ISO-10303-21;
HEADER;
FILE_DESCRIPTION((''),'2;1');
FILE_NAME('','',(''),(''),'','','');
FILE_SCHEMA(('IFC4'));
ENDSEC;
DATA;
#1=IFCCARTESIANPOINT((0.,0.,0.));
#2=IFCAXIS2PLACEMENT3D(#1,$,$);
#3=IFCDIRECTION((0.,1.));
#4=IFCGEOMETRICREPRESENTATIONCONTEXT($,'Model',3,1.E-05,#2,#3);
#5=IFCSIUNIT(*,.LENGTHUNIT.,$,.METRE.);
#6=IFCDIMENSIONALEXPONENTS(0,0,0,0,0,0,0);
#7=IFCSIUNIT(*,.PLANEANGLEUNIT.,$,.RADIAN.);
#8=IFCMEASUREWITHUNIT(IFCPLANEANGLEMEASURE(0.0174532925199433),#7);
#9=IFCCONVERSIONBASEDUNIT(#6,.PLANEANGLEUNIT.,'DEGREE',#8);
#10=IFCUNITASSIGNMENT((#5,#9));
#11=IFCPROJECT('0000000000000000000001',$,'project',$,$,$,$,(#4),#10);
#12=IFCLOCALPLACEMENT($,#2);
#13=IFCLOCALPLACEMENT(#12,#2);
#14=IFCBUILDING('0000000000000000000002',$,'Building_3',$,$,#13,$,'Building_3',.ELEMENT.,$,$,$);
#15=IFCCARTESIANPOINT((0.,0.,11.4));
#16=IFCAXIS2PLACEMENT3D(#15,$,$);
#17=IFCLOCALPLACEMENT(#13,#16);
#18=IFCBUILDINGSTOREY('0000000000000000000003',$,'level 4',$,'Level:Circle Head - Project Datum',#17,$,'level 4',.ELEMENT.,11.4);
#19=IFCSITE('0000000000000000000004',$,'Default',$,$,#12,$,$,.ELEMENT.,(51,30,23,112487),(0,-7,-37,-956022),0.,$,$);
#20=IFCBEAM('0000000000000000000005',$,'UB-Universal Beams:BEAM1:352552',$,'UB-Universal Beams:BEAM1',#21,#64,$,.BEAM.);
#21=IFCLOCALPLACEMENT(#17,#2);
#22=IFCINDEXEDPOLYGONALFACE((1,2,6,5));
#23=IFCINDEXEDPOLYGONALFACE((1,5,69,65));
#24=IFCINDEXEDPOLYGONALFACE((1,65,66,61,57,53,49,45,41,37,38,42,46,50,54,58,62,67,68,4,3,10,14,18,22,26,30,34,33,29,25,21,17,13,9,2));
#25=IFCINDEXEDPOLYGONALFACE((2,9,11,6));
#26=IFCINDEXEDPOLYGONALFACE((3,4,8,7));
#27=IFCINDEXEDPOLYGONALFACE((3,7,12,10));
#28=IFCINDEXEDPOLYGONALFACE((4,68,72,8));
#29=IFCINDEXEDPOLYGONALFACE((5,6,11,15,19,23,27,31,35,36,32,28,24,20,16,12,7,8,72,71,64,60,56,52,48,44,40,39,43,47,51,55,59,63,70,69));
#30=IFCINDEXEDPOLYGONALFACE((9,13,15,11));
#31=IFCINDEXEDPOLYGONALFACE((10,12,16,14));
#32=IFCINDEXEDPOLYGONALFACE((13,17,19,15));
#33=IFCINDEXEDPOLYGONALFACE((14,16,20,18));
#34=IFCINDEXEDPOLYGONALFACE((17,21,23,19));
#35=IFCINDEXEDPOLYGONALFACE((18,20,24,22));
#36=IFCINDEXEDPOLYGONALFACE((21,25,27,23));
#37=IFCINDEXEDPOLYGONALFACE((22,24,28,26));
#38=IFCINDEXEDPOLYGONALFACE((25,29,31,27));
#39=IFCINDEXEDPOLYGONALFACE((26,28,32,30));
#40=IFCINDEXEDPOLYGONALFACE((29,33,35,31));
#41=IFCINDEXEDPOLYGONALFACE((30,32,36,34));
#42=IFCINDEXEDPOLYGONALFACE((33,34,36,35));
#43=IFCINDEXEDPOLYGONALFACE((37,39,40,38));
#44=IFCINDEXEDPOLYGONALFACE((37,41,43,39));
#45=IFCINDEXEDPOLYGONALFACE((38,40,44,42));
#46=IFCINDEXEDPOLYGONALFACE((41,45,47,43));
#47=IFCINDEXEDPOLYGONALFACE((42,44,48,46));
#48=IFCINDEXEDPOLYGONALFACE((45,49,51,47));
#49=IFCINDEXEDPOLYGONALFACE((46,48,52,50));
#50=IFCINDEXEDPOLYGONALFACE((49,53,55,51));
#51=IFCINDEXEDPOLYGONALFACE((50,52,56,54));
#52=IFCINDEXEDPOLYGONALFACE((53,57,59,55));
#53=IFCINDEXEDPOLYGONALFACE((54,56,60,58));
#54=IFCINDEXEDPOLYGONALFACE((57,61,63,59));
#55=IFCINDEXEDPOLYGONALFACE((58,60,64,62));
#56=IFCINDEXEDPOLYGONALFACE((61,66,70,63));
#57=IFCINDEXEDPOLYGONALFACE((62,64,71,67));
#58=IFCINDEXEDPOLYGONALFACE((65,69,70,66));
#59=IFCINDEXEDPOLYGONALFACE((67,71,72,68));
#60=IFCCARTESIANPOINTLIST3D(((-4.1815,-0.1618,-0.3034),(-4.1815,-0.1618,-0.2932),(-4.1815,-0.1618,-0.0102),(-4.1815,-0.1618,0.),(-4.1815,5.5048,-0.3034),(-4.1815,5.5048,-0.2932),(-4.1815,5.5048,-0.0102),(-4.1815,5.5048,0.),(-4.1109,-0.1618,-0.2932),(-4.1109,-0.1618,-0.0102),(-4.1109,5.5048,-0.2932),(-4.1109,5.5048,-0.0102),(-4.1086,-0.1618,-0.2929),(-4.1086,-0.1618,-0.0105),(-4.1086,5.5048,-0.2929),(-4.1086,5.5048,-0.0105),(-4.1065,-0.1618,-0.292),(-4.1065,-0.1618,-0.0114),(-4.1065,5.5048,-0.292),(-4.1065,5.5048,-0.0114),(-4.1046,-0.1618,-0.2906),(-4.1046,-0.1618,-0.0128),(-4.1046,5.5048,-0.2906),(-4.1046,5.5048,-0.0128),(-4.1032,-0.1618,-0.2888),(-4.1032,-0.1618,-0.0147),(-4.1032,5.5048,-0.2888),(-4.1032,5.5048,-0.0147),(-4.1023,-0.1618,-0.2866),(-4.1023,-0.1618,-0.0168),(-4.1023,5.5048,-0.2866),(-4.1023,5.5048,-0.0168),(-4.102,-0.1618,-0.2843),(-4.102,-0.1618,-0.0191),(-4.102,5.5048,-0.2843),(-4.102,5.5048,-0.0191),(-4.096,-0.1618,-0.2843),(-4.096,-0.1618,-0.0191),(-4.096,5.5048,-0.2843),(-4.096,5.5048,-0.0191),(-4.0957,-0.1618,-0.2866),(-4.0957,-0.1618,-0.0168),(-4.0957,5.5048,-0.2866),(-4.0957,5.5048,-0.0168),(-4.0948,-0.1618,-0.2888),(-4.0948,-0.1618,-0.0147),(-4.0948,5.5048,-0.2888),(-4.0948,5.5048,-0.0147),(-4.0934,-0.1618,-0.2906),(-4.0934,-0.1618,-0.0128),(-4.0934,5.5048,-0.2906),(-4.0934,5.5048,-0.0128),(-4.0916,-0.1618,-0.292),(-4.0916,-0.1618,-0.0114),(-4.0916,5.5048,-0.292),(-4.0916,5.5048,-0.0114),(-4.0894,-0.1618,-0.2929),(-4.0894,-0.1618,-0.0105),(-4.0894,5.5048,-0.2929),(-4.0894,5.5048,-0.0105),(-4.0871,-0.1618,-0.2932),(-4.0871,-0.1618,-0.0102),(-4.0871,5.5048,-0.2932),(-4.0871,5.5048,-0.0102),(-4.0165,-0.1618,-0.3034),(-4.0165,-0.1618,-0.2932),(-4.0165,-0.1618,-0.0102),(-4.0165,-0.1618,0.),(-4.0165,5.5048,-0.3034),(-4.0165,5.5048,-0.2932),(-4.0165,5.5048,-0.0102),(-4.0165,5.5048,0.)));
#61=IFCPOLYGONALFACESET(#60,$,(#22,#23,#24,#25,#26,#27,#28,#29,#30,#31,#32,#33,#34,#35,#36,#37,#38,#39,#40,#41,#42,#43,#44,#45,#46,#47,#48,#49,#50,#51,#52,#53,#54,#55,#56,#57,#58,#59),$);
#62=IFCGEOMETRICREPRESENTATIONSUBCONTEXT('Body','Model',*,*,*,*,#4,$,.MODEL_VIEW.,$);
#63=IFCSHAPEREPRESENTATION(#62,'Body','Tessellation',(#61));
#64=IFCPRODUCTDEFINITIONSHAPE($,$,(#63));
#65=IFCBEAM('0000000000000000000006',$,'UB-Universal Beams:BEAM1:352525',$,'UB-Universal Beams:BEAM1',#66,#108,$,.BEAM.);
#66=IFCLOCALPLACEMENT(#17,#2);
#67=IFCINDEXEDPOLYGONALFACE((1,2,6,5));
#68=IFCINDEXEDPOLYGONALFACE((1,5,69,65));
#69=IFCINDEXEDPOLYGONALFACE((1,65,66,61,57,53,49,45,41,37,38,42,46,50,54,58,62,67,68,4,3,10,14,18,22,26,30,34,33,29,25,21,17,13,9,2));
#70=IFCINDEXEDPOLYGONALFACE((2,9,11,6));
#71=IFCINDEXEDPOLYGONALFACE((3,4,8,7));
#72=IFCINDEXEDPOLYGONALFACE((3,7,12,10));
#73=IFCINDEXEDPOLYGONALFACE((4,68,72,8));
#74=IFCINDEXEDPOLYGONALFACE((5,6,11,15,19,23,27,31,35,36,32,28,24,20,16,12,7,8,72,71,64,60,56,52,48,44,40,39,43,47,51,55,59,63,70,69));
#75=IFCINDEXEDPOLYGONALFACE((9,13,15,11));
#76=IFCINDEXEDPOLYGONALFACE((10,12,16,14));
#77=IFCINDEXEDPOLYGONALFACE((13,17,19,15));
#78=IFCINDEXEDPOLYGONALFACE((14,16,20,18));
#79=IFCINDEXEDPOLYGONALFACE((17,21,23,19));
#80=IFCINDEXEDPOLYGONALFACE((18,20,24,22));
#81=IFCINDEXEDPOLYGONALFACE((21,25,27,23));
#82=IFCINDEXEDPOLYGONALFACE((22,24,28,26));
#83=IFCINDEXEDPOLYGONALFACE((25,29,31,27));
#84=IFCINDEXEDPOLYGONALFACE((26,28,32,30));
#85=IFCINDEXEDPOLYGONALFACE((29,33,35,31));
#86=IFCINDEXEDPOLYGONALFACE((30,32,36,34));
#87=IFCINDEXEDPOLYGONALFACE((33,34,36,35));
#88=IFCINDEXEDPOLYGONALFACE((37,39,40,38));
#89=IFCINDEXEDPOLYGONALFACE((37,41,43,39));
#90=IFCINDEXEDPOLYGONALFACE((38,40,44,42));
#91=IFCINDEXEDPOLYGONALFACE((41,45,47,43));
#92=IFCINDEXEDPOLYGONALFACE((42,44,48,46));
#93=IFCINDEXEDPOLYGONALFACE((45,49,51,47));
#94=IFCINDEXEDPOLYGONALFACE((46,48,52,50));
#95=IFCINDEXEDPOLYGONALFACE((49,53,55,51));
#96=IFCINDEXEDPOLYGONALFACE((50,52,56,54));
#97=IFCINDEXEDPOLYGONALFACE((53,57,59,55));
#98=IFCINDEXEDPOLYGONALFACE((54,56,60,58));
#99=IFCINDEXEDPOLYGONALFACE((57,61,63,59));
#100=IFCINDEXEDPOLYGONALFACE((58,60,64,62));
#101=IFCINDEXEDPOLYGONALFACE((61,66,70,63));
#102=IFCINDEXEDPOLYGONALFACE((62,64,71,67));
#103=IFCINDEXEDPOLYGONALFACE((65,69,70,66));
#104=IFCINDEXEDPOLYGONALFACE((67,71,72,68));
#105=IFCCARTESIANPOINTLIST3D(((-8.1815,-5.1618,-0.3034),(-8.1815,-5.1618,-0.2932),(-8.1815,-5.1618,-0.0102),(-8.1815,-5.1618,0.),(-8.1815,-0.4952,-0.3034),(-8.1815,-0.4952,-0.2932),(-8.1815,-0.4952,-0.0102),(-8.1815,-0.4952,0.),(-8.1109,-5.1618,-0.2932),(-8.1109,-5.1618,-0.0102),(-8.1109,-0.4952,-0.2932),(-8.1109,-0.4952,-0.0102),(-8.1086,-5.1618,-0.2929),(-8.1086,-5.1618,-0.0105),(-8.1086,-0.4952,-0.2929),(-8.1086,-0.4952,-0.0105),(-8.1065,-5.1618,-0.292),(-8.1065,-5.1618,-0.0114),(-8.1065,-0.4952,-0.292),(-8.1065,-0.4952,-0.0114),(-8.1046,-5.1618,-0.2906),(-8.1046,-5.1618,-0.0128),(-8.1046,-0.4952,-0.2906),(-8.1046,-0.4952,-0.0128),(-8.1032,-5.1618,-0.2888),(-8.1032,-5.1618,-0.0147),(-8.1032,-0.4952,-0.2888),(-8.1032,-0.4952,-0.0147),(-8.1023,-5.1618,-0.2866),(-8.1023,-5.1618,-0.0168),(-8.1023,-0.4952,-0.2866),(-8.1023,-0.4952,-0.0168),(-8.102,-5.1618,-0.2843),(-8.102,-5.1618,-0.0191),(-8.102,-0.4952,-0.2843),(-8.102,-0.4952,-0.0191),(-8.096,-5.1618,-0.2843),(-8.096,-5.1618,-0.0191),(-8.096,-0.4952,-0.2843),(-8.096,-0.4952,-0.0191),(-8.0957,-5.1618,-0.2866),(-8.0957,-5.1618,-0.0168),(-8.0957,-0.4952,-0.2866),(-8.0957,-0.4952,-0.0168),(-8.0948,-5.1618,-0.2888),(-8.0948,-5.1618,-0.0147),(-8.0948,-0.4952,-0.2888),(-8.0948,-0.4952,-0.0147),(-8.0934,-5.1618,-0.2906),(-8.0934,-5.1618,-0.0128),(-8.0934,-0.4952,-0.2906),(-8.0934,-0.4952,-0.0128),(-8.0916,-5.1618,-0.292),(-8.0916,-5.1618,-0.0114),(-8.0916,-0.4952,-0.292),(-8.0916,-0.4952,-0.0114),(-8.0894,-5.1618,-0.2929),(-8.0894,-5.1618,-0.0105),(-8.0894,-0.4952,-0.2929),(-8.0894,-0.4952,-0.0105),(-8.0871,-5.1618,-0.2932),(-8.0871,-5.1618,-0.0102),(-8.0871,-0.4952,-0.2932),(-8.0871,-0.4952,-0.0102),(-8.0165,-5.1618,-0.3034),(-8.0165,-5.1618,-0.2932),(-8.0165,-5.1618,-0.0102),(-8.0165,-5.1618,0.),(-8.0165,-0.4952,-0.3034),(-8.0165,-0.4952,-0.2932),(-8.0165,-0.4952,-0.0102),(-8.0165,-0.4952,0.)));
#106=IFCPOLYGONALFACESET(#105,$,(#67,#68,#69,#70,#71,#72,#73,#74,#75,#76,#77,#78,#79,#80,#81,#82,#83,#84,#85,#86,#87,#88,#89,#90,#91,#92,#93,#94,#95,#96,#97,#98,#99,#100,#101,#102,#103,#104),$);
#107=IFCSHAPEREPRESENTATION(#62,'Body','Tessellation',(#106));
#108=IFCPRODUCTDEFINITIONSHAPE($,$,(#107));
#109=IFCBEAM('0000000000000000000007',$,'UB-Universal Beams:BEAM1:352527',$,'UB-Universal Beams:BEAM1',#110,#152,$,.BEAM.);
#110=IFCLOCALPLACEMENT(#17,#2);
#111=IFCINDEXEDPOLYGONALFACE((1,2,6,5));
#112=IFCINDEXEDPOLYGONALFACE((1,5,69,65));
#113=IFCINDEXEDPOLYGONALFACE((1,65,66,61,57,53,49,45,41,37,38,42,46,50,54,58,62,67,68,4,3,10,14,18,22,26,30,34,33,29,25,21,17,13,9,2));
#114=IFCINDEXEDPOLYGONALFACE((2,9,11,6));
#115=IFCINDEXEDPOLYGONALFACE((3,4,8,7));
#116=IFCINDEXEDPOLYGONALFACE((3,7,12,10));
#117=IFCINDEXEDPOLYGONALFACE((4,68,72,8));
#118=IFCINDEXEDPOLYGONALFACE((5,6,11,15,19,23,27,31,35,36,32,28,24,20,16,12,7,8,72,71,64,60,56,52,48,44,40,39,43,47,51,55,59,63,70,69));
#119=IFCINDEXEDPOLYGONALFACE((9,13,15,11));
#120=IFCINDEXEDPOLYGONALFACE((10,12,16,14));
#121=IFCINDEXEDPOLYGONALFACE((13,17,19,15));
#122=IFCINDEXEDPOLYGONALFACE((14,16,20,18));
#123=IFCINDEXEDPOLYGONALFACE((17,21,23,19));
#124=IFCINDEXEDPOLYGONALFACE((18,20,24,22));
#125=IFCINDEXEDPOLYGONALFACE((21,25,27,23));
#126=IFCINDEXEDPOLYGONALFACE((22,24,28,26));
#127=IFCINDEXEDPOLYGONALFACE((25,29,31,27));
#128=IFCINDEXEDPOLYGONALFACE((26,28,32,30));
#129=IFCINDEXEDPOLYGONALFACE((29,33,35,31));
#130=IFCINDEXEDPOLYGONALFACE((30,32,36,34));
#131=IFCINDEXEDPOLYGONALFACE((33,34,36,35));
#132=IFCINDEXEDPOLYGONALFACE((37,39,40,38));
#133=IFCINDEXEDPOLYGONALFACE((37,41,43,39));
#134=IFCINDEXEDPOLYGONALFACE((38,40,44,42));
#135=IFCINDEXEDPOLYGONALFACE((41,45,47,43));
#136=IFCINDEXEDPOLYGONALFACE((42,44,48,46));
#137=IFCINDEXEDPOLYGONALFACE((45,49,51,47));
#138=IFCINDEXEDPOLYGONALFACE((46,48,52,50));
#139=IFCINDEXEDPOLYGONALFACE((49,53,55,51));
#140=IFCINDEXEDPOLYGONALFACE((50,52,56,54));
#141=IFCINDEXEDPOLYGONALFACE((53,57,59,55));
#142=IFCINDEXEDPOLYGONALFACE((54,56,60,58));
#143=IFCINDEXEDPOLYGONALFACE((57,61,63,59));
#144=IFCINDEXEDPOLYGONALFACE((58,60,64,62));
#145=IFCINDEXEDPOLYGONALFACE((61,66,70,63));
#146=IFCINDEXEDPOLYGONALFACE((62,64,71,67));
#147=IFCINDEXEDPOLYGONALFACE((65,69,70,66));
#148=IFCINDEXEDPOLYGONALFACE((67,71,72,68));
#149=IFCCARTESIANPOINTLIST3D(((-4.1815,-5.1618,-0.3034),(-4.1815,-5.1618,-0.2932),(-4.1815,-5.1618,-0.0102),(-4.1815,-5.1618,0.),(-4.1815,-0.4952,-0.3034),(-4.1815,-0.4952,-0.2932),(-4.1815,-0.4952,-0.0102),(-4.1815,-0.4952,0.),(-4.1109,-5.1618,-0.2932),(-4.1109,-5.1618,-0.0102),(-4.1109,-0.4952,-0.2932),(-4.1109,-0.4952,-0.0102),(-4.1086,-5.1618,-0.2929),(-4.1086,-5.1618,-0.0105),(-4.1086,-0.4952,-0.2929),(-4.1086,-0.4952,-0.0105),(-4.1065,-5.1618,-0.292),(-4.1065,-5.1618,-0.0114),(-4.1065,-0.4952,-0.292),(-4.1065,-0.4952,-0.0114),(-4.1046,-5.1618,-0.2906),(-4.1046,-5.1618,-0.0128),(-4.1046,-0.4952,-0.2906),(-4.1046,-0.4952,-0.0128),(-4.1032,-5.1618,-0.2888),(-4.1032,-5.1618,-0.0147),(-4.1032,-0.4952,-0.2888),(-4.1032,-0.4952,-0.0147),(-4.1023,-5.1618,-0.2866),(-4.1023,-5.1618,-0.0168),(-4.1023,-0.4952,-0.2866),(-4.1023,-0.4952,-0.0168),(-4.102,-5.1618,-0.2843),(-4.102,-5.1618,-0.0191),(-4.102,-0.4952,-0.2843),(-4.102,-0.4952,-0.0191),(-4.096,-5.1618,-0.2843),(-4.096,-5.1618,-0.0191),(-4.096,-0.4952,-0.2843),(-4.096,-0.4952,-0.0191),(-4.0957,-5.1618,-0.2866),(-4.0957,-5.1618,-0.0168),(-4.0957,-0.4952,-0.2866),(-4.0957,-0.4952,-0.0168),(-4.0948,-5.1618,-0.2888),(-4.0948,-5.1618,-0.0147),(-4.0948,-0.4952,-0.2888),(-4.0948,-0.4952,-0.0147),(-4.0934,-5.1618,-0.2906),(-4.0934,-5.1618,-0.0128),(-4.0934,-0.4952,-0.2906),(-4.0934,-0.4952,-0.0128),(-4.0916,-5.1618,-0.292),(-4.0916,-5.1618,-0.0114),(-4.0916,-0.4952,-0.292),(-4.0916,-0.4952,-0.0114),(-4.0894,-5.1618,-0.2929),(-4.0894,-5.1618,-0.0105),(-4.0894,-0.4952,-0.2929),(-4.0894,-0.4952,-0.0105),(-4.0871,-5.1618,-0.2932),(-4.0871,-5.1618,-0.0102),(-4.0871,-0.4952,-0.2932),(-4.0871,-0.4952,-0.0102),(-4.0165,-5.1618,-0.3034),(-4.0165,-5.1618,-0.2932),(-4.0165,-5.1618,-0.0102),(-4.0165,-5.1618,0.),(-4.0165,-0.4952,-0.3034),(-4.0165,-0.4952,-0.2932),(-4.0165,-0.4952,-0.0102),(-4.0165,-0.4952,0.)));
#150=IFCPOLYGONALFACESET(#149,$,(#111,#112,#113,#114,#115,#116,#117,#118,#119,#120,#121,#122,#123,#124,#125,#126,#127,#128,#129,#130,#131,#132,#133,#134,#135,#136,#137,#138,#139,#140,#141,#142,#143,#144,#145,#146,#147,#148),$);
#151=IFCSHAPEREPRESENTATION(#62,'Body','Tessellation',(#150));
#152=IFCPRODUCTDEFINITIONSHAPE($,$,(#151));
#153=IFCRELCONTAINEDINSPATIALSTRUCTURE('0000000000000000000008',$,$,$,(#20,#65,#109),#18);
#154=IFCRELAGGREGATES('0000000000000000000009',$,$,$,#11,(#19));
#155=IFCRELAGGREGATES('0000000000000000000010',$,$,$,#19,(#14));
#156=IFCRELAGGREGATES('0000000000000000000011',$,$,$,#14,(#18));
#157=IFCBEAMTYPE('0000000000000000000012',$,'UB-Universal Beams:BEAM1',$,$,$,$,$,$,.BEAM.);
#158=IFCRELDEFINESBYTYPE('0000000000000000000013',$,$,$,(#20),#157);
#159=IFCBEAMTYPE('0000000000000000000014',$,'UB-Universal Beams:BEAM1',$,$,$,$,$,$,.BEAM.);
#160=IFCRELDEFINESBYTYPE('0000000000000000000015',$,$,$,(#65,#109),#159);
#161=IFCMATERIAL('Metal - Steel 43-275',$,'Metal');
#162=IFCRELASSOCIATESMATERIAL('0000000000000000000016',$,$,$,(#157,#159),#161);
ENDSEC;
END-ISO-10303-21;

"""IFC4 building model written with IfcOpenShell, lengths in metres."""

from ifc_helpers import new_model, entity, si_unit, converted_unit, direction, frame, frame_2d, origin, place, context, subcontext, project, spatial, polyline, circle_curve, parameter, trimmed, segment, composite_curve, outline, extrude, source, transform, mapped, material, material_profile, profile_set, type_object, type_shapes, element, save


model = new_model("IFC4")

# Units and contexts
model_context = context("Model", 3, precision=1e-05, world=origin(), true_north=direction((0.0, 1.0)))
body_context = subcontext(model_context, "Body", "Model", "MODEL_VIEW")
ifc_project = project(units=[si_unit("LENGTHUNIT", "METRE"), converted_unit("PLANEANGLEUNIT", "DEGREE", entity("IfcPlaneAngleMeasure", 0.0174532925199433), si_unit("PLANEANGLEUNIT", "RADIAN"), dimensions=[0, 0, 0, 0, 0, 0, 0])], contexts=[model_context])

# Site, building, storey
site_placement = place(None, origin())
site = spatial("IfcSite", under=ifc_project, at=site_placement, Name="Default", CompositionType="ELEMENT", RefLatitude=(51, 30, 23, 112487), RefLongitude=(0, -7, -37, -956022), RefElevation=0.0)
building_placement = place(site_placement, origin())
building = spatial("IfcBuilding", under=site, at=building_placement, Name="Building_3", LongName="Building_3", CompositionType="ELEMENT")
storey_placement = place(building_placement, frame((0.0, 0.0, 11.4)))
storey = spatial("IfcBuildingStorey", under=building, at=storey_placement, Name="level 4", ObjectType="Level:Circle Head - Project Datum", LongName="level 4", CompositionType="ELEMENT", Elevation=11.4)

# Shared definitions
ifc_material_1 = material(Name="Metal - Steel 43-275", Category="Metal")

# Beams
ifc_material_profile_1 = material_profile(ifc_material_1, outline(composite_curve([segment(polyline([(-0.0825, -0.1415), (-0.0825, -0.1517)]), True, "CONTINUOUS"), segment(polyline([(-0.0825, -0.1517), (0.0825, -0.1517)]), True, "CONTINUOUS"), segment(polyline([(0.0825, -0.1517), (0.0825, -0.1415)]), True, "CONTINUOUS"), segment(polyline([(0.0825, -0.1415), (0.0119, -0.1415)]), True, "CONTINUOUS"), segment(trimmed(circle_curve(frame_2d((0.0119, -0.1326), x_axis=(1.0, 0.0)), 0.0089), [parameter(180.0)], [parameter(270.0)], True, "PARAMETER"), False, "CONTINUOUS"), segment(polyline([(0.003, -0.1326), (0.003, 0.1326)]), True, "CONTINUOUS"), segment(trimmed(circle_curve(frame_2d((0.0119, 0.1326), x_axis=(1.0, 0.0)), 0.0089), [parameter(90.0)], [parameter(180.0)], True, "PARAMETER"), False, "CONTINUOUS"), segment(polyline([(0.0119, 0.1415), (0.0825, 0.1415)]), True, "CONTINUOUS"), segment(polyline([(0.0825, 0.1415), (0.0825, 0.1517)]), True, "CONTINUOUS"), segment(polyline([(0.0825, 0.1517), (-0.0825, 0.1517)]), True, "CONTINUOUS"), segment(polyline([(-0.0825, 0.1517), (-0.0825, 0.1415)]), True, "CONTINUOUS"), segment(polyline([(-0.0825, 0.1415), (-0.0119, 0.1415)]), True, "CONTINUOUS"), segment(trimmed(circle_curve(frame_2d((-0.0119, 0.1326), x_axis=(1.0, 0.0)), 0.0089), [parameter(360.0)], [parameter(90.0)], True, "PARAMETER"), False, "CONTINUOUS"), segment(polyline([(-0.003, 0.1326), (-0.003, -0.1326)]), True, "CONTINUOUS"), segment(trimmed(circle_curve(frame_2d((-0.0119, -0.1326), x_axis=(1.0, 0.0)), 0.0089), [parameter(270.0)], [parameter(360.0)], True, "PARAMETER"), False, "CONTINUOUS"), segment(polyline([(-0.0119, -0.1415), (-0.0825, -0.1415)]), True, "CONTINUOUS")], self_intersect=False)), Name="BEAM1")
ifc_profile_set_1 = profile_set([ifc_material_profile_1], Name="BEAM1")
beam_type_1 = type_object("IfcBeamType", Name="UB-Universal Beams:BEAM1", PredefinedType="BEAM", material=ifc_profile_set_1)
shared_shape_1 = source(origin(), body_context, "Body", "SweptSolid", [
    extrude(outline(composite_curve([segment(polyline([(-0.0825, -0.1415), (-0.0825, -0.1517)]), True, "CONTINUOUS"), segment(polyline([(-0.0825, -0.1517), (0.0825, -0.1517)]), True, "CONTINUOUS"), segment(polyline([(0.0825, -0.1517), (0.0825, -0.1415)]), True, "CONTINUOUS"), segment(polyline([(0.0825, -0.1415), (0.0119, -0.1415)]), True, "CONTINUOUS"), segment(trimmed(circle_curve(frame_2d((0.0119, -0.1326), x_axis=(1.0, 0.0)), 0.0089), [parameter(180.0)], [parameter(270.0)], True, "PARAMETER"), False, "CONTINUOUS"), segment(polyline([(0.003, -0.1326), (0.003, 0.1326)]), True, "CONTINUOUS"), segment(trimmed(circle_curve(frame_2d((0.0119, 0.1326), x_axis=(1.0, 0.0)), 0.0089), [parameter(90.0)], [parameter(180.0)], True, "PARAMETER"), False, "CONTINUOUS"), segment(polyline([(0.0119, 0.1415), (0.0825, 0.1415)]), True, "CONTINUOUS"), segment(polyline([(0.0825, 0.1415), (0.0825, 0.1517)]), True, "CONTINUOUS"), segment(polyline([(0.0825, 0.1517), (-0.0825, 0.1517)]), True, "CONTINUOUS"), segment(polyline([(-0.0825, 0.1517), (-0.0825, 0.1415)]), True, "CONTINUOUS"), segment(polyline([(-0.0825, 0.1415), (-0.0119, 0.1415)]), True, "CONTINUOUS"), segment(trimmed(circle_curve(frame_2d((-0.0119, 0.1326), x_axis=(1.0, 0.0)), 0.0089), [parameter(360.0)], [parameter(90.0)], True, "PARAMETER"), False, "CONTINUOUS"), segment(polyline([(-0.003, 0.1326), (-0.003, -0.1326)]), True, "CONTINUOUS"), segment(trimmed(circle_curve(frame_2d((-0.0119, -0.1326), x_axis=(1.0, 0.0)), 0.0089), [parameter(270.0)], [parameter(360.0)], True, "PARAMETER"), False, "CONTINUOUS"), segment(polyline([(-0.0119, -0.1415), (-0.0825, -0.1415)]), True, "CONTINUOUS")], self_intersect=False)), frame((-2.8333, 0.0, 0.0), z_axis=(-1.0, 0.0, 0.0), x_axis=(0.0, -1.0, 0.0)), (0.0, 0.0, -1.0), 5.6666),
])
type_shapes(beam_type_1, [shared_shape_1])
for number, where, z_axis, x_axis, name in (
    (1, (-4.099, 2.6715, -0.1517), (0.0, 0.0, 1.0), (0.0, -1.0, 0.0), "UB-Universal Beams:BEAM1:352552"),
):
    element("IfcBeam", number, at=place(storey_placement, frame(where, z_axis=z_axis, x_axis=x_axis)), inside=storey, type_object=beam_type_1, Name=name, ObjectType="UB-Universal Beams:BEAM1", PredefinedType="BEAM", context=body_context, shape_type="MappedRepresentation", body=[
        mapped(shared_shape_1, transform((0.0, 0.0, 0.0), scale=1.0)),
    ])
beam_type_2 = type_object("IfcBeamType", Name="UB-Universal Beams:BEAM1", PredefinedType="BEAM", material=ifc_profile_set_1)
shared_shape_2 = source(origin(), body_context, "Body", "SweptSolid", [
    extrude(outline(composite_curve([segment(polyline([(-0.0825, -0.1415), (-0.0825, -0.1517)]), True, "CONTINUOUS"), segment(polyline([(-0.0825, -0.1517), (0.0825, -0.1517)]), True, "CONTINUOUS"), segment(polyline([(0.0825, -0.1517), (0.0825, -0.1415)]), True, "CONTINUOUS"), segment(polyline([(0.0825, -0.1415), (0.0119, -0.1415)]), True, "CONTINUOUS"), segment(trimmed(circle_curve(frame_2d((0.0119, -0.1326), x_axis=(0.0, -1.0)), 0.0089), [parameter(270.0)], [parameter(360.0)], True, "PARAMETER"), False, "CONTINUOUS"), segment(polyline([(0.003, -0.1326), (0.003, 0.1326)]), True, "CONTINUOUS"), segment(trimmed(circle_curve(frame_2d((0.0119, 0.1326), x_axis=(-1.0, 0.0)), 0.0089), [parameter(270.0)], [parameter(360.0)], True, "PARAMETER"), False, "CONTINUOUS"), segment(polyline([(0.0119, 0.1415), (0.0825, 0.1415)]), True, "CONTINUOUS"), segment(polyline([(0.0825, 0.1415), (0.0825, 0.1517)]), True, "CONTINUOUS"), segment(polyline([(0.0825, 0.1517), (-0.0825, 0.1517)]), True, "CONTINUOUS"), segment(polyline([(-0.0825, 0.1517), (-0.0825, 0.1415)]), True, "CONTINUOUS"), segment(polyline([(-0.0825, 0.1415), (-0.0119, 0.1415)]), True, "CONTINUOUS"), segment(trimmed(circle_curve(frame_2d((-0.0119, 0.1326), x_axis=(0.0, 1.0)), 0.0089), [parameter(270.0)], [parameter(360.0)], True, "PARAMETER"), False, "CONTINUOUS"), segment(polyline([(-0.003, 0.1326), (-0.003, -0.1326)]), True, "CONTINUOUS"), segment(trimmed(circle_curve(frame_2d((-0.0119, -0.1326), x_axis=(1.0, 0.0)), 0.0089), [parameter(270.0)], [parameter(0.0)], True, "PARAMETER"), False, "CONTINUOUS"), segment(polyline([(-0.0119, -0.1415), (-0.0825, -0.1415)]), True, "CONTINUOUS")], self_intersect=False)), frame((-2.3333, 0.0, 0.0), z_axis=(-1.0, 0.0, 0.0), x_axis=(0.0, -1.0, 0.0)), (0.0, 0.0, -1.0), 4.6666),
])
type_shapes(beam_type_2, [shared_shape_2])
for number, where, z_axis, x_axis, name in (
    (2, (-8.099, -2.8285, -0.1517), (0.0, 0.0, 1.0), (0.0, 1.0, 0.0), "UB-Universal Beams:BEAM1:352525"),
    (3, (-4.099, -2.8285, -0.1517), (0.0, 0.0, 1.0), (0.0, 1.0, 0.0), "UB-Universal Beams:BEAM1:352527"),
):
    element("IfcBeam", number, at=place(storey_placement, frame(where, z_axis=z_axis, x_axis=x_axis)), inside=storey, type_object=beam_type_2, Name=name, ObjectType="UB-Universal Beams:BEAM1", PredefinedType="BEAM", context=body_context, shape_type="MappedRepresentation", body=[
        mapped(shared_shape_2, transform((0.0, 0.0, 0.0), scale=1.0)),
    ])

save(model, "model.ifc")
